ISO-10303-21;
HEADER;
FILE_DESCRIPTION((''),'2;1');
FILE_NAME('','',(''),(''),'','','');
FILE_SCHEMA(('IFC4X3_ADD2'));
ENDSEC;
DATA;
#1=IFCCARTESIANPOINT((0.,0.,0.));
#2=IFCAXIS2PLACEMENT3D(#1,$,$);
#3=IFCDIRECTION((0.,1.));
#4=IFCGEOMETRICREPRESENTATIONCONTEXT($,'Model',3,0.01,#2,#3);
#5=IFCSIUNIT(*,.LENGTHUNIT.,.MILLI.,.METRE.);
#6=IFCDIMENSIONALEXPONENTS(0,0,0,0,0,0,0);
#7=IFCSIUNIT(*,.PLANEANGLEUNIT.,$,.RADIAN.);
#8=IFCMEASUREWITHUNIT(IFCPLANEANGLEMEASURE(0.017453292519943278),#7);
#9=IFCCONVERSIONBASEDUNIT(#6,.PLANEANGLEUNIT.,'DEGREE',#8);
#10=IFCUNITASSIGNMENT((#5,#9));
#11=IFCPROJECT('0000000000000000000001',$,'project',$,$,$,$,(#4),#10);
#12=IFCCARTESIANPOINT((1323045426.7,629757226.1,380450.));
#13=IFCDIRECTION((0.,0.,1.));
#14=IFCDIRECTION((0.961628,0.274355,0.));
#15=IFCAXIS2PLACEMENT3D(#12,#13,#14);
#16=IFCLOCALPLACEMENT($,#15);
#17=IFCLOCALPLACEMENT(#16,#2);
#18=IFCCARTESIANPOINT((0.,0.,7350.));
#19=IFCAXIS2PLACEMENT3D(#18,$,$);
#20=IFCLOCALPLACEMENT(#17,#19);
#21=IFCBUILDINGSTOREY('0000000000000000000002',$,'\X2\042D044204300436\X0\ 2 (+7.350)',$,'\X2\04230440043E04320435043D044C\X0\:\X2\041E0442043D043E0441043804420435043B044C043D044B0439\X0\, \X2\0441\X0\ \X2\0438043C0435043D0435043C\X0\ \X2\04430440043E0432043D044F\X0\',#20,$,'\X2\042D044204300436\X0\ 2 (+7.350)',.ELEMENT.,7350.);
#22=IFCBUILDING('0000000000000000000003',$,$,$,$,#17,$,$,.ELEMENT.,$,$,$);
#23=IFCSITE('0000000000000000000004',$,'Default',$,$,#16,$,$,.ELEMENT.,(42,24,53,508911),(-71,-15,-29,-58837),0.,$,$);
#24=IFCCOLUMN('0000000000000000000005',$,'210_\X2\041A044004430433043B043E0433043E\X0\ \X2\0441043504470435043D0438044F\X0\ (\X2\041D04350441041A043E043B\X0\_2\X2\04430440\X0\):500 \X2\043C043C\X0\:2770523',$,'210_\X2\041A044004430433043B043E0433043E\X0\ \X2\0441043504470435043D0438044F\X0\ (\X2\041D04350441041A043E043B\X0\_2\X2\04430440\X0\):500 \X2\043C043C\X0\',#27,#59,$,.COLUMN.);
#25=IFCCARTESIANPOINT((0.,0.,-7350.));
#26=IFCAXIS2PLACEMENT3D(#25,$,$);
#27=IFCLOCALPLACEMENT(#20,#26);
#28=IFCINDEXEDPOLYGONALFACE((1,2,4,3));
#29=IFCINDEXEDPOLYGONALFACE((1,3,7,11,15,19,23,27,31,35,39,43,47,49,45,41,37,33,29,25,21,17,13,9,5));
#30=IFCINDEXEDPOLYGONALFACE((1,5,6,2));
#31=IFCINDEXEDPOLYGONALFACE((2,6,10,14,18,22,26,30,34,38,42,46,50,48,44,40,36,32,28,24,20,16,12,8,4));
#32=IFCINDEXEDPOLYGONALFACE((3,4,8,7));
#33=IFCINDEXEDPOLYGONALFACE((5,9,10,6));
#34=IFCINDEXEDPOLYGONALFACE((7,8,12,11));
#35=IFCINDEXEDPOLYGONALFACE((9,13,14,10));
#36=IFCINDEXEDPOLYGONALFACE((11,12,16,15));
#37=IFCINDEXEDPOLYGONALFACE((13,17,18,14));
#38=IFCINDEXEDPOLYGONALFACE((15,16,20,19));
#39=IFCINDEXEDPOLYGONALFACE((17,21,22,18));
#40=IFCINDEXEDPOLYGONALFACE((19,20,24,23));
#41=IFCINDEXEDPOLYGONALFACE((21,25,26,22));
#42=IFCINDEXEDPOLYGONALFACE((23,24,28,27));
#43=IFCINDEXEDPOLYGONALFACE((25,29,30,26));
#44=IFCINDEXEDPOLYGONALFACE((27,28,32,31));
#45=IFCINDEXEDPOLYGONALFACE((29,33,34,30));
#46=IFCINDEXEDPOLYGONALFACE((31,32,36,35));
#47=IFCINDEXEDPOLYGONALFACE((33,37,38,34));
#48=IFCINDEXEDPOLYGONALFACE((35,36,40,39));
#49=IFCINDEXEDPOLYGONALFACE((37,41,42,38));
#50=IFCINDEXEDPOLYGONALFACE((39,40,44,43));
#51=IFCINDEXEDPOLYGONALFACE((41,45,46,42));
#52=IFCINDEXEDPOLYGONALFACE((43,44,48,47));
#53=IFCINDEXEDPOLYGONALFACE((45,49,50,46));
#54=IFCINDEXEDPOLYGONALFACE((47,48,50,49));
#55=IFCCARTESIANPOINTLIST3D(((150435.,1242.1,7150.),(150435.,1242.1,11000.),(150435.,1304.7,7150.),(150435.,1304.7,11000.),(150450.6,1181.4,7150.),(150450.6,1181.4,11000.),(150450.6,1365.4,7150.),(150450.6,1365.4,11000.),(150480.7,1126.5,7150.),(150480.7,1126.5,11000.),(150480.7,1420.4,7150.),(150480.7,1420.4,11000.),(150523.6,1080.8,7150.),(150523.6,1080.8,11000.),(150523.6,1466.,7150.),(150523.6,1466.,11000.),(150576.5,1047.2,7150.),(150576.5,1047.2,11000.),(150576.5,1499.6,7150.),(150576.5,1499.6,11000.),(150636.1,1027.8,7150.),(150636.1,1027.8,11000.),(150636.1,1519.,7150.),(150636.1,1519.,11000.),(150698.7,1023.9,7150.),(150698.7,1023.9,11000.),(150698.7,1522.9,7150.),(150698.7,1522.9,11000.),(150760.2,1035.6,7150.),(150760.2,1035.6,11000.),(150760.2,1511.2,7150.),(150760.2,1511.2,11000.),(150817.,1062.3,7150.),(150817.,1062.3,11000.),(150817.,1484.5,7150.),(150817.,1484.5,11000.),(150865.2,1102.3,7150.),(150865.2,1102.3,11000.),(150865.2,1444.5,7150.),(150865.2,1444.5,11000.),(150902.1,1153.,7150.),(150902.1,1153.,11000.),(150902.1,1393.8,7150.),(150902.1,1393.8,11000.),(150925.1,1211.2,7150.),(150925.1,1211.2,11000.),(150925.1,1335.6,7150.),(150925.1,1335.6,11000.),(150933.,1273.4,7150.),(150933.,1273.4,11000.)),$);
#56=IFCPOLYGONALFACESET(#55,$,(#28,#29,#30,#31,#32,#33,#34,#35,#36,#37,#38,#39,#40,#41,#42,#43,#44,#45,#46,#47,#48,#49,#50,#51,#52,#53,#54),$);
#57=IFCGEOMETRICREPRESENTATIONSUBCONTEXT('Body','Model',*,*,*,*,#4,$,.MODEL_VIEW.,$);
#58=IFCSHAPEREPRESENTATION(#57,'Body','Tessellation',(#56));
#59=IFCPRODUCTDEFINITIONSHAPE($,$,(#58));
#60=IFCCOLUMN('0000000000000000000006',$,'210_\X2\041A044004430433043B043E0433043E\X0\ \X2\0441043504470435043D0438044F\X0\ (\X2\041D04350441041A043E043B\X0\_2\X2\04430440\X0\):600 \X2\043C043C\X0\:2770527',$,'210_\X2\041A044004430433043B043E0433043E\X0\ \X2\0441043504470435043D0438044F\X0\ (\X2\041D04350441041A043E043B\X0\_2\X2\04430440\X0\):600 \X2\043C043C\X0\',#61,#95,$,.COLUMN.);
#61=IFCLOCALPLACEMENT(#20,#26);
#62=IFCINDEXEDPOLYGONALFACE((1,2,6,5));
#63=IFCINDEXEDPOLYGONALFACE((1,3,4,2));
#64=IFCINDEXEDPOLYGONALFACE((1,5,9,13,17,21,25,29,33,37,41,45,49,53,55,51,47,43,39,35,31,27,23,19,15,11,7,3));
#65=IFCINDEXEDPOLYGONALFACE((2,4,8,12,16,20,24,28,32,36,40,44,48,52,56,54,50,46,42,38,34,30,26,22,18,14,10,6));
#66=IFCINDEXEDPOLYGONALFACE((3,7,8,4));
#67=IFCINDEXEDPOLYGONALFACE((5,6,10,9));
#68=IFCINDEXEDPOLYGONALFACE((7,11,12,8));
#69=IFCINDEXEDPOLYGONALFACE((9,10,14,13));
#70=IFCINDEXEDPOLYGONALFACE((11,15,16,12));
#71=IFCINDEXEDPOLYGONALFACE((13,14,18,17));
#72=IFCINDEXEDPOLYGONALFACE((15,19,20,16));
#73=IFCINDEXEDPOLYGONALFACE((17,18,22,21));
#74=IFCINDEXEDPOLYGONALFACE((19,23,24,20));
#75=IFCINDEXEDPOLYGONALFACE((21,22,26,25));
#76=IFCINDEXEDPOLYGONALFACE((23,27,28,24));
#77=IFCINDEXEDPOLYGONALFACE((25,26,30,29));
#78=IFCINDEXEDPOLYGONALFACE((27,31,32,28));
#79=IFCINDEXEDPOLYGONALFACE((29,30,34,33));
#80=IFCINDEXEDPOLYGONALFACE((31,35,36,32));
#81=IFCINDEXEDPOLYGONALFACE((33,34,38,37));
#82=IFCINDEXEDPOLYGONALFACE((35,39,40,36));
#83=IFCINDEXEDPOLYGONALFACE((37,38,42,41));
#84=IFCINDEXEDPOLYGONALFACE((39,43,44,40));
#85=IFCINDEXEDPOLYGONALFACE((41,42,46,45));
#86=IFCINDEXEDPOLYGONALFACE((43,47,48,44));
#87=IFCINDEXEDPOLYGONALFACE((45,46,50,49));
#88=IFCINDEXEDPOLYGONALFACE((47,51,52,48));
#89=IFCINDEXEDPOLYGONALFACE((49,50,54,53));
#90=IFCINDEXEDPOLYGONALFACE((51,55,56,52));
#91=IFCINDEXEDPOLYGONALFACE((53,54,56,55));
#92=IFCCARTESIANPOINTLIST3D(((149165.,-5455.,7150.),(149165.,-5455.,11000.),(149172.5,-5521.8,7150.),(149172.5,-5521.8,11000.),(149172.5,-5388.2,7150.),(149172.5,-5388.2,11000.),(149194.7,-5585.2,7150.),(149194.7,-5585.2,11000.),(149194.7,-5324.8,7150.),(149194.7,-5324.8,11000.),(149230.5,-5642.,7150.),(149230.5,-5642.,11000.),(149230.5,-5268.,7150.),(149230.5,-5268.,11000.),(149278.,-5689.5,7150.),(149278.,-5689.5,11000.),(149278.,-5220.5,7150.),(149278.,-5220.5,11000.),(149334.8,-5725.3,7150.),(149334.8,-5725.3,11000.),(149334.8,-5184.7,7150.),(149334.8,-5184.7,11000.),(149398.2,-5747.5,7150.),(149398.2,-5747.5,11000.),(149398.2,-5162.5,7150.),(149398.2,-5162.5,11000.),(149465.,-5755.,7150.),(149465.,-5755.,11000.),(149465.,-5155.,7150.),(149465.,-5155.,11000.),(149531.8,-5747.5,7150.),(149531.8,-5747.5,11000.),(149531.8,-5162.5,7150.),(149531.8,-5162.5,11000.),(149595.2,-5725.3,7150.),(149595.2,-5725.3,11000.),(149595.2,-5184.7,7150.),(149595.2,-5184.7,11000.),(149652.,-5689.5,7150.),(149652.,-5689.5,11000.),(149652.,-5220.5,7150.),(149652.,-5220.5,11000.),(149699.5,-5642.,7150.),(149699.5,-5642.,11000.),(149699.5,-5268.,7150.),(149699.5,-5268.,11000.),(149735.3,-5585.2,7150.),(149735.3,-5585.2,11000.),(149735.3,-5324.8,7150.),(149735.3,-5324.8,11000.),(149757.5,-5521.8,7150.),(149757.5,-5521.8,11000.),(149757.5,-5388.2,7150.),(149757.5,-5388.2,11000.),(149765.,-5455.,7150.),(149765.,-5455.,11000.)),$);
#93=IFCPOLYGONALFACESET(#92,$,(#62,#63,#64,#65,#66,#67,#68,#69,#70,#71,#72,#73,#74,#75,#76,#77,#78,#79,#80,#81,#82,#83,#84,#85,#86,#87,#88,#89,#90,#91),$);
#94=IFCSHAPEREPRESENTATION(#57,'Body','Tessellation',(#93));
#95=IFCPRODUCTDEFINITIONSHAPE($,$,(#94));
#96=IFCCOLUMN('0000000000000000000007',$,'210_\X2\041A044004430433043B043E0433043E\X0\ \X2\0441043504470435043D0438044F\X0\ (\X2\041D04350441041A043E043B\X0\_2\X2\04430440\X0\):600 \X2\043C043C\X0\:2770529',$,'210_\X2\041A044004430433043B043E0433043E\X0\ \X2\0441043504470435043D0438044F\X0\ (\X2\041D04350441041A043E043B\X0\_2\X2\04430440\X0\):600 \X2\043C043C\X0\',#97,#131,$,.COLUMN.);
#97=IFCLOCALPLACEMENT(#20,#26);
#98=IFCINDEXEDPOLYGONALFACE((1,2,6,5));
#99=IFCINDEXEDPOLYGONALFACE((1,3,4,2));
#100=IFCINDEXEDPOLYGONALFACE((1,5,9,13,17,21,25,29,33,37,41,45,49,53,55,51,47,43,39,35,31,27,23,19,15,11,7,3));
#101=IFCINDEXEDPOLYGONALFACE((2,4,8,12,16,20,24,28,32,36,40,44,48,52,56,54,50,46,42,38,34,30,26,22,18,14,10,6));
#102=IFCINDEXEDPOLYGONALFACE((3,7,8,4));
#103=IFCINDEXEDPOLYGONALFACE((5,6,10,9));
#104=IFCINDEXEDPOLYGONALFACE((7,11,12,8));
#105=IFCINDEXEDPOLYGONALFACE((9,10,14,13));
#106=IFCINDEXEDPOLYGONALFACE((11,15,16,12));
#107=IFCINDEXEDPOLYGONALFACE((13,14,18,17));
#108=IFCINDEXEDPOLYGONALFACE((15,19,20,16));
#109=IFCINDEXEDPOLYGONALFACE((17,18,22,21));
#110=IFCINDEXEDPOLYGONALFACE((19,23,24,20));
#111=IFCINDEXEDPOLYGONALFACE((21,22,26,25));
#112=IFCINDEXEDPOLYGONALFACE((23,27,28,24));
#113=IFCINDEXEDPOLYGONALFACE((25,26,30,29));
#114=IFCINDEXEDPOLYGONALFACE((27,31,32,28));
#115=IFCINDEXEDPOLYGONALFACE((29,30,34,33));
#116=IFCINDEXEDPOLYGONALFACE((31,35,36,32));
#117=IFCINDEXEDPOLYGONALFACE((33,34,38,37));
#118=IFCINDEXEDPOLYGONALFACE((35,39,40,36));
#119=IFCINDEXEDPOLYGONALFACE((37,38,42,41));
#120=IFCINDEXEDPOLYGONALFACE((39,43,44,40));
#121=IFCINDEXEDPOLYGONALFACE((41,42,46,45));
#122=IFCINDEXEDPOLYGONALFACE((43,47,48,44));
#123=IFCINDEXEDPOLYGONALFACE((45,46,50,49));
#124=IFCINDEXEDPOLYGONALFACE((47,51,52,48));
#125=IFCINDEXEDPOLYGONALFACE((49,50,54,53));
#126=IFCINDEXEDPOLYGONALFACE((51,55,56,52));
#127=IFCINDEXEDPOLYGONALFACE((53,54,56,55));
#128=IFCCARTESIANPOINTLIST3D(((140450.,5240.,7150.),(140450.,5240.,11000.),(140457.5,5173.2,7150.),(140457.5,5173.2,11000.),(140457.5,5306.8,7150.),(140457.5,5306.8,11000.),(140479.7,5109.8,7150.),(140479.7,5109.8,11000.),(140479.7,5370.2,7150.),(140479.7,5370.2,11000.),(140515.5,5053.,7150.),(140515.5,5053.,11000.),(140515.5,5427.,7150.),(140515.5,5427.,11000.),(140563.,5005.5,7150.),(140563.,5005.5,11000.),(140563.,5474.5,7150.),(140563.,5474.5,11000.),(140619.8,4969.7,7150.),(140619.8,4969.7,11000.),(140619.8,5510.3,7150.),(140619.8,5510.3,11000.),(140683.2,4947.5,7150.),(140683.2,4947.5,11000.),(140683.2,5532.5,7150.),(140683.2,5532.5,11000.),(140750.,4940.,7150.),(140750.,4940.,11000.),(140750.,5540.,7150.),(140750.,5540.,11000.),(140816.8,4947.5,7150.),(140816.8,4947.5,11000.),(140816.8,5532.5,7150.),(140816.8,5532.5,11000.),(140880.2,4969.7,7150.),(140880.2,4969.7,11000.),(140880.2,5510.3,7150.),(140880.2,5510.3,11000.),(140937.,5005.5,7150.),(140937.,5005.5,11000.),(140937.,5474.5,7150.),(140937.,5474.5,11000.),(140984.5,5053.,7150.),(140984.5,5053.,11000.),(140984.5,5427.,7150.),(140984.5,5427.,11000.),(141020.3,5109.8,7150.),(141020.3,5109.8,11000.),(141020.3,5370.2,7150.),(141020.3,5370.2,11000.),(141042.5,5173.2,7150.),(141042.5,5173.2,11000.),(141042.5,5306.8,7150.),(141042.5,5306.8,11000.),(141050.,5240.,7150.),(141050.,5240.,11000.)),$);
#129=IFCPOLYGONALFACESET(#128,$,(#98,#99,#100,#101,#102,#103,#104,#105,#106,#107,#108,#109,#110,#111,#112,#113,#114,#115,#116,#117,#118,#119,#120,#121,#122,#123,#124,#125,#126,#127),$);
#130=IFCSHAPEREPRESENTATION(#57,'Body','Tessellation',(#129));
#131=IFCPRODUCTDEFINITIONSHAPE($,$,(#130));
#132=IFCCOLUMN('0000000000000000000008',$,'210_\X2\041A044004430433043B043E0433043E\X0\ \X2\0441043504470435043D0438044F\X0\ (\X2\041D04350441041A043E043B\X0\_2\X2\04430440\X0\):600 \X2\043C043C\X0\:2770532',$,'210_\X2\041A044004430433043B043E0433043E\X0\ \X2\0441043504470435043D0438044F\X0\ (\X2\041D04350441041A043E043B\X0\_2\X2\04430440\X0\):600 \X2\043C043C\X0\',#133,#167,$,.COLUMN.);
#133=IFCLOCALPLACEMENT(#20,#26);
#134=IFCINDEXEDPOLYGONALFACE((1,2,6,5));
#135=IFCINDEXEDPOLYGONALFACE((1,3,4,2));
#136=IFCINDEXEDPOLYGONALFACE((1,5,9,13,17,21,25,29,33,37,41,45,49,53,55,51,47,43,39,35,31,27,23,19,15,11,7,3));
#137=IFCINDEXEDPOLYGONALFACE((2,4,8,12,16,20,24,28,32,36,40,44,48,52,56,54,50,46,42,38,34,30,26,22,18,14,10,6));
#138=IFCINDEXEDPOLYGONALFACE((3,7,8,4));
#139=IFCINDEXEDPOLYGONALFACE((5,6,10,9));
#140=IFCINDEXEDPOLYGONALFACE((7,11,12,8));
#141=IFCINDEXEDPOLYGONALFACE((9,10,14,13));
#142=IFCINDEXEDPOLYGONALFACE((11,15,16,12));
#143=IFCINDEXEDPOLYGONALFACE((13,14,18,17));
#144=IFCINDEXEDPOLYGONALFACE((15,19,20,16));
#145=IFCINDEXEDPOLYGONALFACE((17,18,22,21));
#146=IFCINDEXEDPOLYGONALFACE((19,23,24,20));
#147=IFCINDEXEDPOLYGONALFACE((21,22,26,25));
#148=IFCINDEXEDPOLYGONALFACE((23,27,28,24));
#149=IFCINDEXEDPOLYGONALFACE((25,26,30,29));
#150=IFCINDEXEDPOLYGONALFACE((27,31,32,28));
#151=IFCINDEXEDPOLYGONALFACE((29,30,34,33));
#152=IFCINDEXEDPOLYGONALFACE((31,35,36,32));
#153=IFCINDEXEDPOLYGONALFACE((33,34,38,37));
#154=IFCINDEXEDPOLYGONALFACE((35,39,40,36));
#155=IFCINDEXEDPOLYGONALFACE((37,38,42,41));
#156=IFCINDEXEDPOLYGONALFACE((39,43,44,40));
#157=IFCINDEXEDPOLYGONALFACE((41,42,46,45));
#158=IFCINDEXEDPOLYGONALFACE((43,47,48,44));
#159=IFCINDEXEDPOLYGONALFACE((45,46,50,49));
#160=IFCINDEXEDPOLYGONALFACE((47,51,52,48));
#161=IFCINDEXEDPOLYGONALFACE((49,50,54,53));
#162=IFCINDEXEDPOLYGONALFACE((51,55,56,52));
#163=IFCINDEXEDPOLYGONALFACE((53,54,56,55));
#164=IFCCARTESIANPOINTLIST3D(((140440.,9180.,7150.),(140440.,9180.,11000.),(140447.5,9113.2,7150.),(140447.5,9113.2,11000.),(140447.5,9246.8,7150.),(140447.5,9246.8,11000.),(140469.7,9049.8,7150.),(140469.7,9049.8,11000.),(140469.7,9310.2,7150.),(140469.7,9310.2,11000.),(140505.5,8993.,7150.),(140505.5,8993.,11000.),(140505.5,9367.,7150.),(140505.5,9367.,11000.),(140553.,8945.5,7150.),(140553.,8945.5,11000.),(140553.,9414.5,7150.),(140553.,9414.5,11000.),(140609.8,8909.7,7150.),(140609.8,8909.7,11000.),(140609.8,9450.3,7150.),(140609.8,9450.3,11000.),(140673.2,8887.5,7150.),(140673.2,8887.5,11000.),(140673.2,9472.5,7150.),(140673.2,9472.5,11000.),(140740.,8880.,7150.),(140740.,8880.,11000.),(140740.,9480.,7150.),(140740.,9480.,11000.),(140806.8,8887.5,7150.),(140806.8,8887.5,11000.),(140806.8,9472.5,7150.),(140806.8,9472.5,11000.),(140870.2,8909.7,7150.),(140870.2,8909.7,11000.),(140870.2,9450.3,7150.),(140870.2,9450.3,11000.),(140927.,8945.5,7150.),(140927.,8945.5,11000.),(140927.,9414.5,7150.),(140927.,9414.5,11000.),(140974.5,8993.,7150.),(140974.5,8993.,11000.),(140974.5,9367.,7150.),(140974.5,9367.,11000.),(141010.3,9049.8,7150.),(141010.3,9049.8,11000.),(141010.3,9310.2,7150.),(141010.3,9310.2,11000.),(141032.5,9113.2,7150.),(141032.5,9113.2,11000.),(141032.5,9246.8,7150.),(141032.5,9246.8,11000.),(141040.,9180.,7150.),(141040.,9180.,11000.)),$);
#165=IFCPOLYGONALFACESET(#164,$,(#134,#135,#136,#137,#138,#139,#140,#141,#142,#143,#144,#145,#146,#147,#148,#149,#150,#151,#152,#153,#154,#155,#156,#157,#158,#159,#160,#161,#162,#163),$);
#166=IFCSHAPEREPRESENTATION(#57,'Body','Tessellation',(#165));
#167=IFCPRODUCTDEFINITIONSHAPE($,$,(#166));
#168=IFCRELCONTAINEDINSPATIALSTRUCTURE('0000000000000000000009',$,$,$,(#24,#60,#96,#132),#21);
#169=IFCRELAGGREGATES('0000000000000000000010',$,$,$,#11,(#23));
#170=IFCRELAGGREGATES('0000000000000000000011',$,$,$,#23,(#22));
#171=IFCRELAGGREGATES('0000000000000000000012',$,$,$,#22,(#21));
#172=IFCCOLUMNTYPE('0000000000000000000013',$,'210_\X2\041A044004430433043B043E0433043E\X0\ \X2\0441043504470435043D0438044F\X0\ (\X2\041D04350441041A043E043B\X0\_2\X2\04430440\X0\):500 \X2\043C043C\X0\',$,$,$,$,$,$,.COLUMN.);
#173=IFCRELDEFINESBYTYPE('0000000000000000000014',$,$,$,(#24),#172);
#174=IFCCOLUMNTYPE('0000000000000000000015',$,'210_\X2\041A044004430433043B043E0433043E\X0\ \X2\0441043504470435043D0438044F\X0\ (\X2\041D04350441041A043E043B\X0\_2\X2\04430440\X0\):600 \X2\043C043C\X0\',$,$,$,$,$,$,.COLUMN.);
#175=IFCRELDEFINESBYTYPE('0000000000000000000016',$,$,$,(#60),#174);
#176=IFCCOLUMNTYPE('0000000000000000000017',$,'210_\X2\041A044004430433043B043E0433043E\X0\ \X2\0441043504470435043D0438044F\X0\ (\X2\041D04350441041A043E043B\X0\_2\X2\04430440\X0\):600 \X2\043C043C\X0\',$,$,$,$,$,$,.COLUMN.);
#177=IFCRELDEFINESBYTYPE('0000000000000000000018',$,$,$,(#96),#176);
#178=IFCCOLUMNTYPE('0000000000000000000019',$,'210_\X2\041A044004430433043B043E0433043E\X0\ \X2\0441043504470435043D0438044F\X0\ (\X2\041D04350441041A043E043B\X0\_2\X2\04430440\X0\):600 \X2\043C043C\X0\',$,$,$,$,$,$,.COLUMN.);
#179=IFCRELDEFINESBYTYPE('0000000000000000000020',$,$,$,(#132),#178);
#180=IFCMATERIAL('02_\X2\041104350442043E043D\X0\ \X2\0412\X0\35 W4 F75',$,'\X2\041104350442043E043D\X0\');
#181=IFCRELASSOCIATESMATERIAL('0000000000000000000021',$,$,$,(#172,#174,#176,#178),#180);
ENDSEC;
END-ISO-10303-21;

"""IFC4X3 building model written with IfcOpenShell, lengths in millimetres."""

from ifc_helpers import new_model, entity, si_unit, converted_unit, direction, frame, frame_2d, origin, origin_2d_with_axis, place, context, subcontext, project, spatial, circle, extrude, source, transform, mapped, material, material_profile, profile_set, type_object, type_shapes, element, save


model = new_model("IFC4X3")

# Units and contexts
model_context = context("Model", 3, precision=0.01, world=origin(), true_north=direction((0.0, 1.0)))
body_context = subcontext(model_context, "Body", "Model", "MODEL_VIEW")
ifc_project = project(units=[si_unit("LENGTHUNIT", "METRE", prefix="MILLI"), converted_unit("PLANEANGLEUNIT", "DEGREE", entity("IfcPlaneAngleMeasure", 0.017453292519943278), si_unit("PLANEANGLEUNIT", "RADIAN"), dimensions=[0, 0, 0, 0, 0, 0, 0])], contexts=[model_context])

# Site, building, storey
site_placement = place(None, frame((1323045426.7, 629757226.1, 380450.0), z_axis=(0.0, 0.0, 1.0), x_axis=(0.961628, 0.274355, 0.0)))
site = spatial("IfcSite", under=ifc_project, at=site_placement, Name="Default", CompositionType="ELEMENT", RefLatitude=(42, 24, 53, 508911), RefLongitude=(-71, -15, -29, -58837), RefElevation=0.0)
building_placement = place(site_placement, origin())
building = spatial("IfcBuilding", under=site, at=building_placement, CompositionType="ELEMENT")
storey_placement = place(building_placement, frame((0.0, 0.0, 7350.0)))
storey = spatial("IfcBuildingStorey", under=building, at=storey_placement, Name="Этаж 2 (+7.350)", ObjectType="Уровень:Относительный, с именем уровня", LongName="Этаж 2 (+7.350)", CompositionType="ELEMENT", Elevation=7350.0)

# Columns
ifc_material = material(Name="02_Бетон В35 W4 F75", Category="Бетон")
ifc_material_profile_1 = material_profile(ifc_material, circle(Radius=250.0, at=frame_2d((0.0, 0.0), x_axis=(1.0, 0.0))), Name="500 мм")
ifc_profile_set_1 = profile_set([ifc_material_profile_1], Name="500 мм")
column_type_1 = type_object("IfcColumnType", Name="210_Круглого сечения (НесКол_2ур):500 мм", PredefinedType="COLUMN", material=ifc_profile_set_1)
shared_shape_1 = source(origin(), body_context, "Body", "SweptSolid", [
    extrude(circle(Radius=250.0, at=frame_2d((0.0, 0.0), x_axis=(1.0, 0.0))), frame((150683.0, 1273.4, 7150.0)), (0.0, 0.0, 1.0), 3850.0),
])
type_shapes(column_type_1, [shared_shape_1])
column_1_placement = place(storey_placement, frame((0.0, 0.0, -7350.0)))
element("IfcColumn", 1, at=column_1_placement, inside=storey, type_object=column_type_1, Name="210_Круглого сечения (НесКол_2ур):500 мм:2770523", ObjectType="210_Круглого сечения (НесКол_2ур):500 мм", PredefinedType="COLUMN", context=body_context, shape_type="MappedRepresentation", body=[
    mapped(shared_shape_1, transform((0.0, 0.0, 0.0), scale=1.0)),
])
ifc_material_profile_2 = material_profile(ifc_material, circle(Radius=300.0, at=origin_2d_with_axis()), Name="600 мм")
ifc_profile_set_2 = profile_set([ifc_material_profile_2], Name="600 мм")
column_type_2 = type_object("IfcColumnType", Name="210_Круглого сечения (НесКол_2ур):600 мм", PredefinedType="COLUMN", material=ifc_profile_set_2)
shared_shape_2 = source(origin(), body_context, "Body", "SweptSolid", [
    extrude(circle(Radius=300.0, at=origin_2d_with_axis()), frame((149465.0, -5455.0, 7150.0)), (0.0, 0.0, 1.0), 3850.0),
])
type_shapes(column_type_2, [shared_shape_2])
column_2_placement = place(storey_placement, frame((0.0, 0.0, -7350.0)))
element("IfcColumn", 2, at=column_2_placement, inside=storey, type_object=column_type_2, Name="210_Круглого сечения (НесКол_2ур):600 мм:2770527", ObjectType="210_Круглого сечения (НесКол_2ур):600 мм", PredefinedType="COLUMN", context=body_context, shape_type="MappedRepresentation", body=[
    mapped(shared_shape_2, transform((0.0, 0.0, 0.0), scale=1.0)),
])
column_type_3 = type_object("IfcColumnType", Name="210_Круглого сечения (НесКол_2ур):600 мм", PredefinedType="COLUMN", material=ifc_profile_set_2)
shared_shape_3 = source(origin(), body_context, "Body", "SweptSolid", [
    extrude(circle(Radius=300.0, at=origin_2d_with_axis()), frame((140750.0, 5240.0, 7150.0)), (0.0, 0.0, 1.0), 3850.0),
])
type_shapes(column_type_3, [shared_shape_3])
column_3_placement = place(storey_placement, frame((0.0, 0.0, -7350.0)))
element("IfcColumn", 3, at=column_3_placement, inside=storey, type_object=column_type_3, Name="210_Круглого сечения (НесКол_2ур):600 мм:2770529", ObjectType="210_Круглого сечения (НесКол_2ур):600 мм", PredefinedType="COLUMN", context=body_context, shape_type="MappedRepresentation", body=[
    mapped(shared_shape_3, transform((0.0, 0.0, 0.0), scale=1.0)),
])
column_type_4 = type_object("IfcColumnType", Name="210_Круглого сечения (НесКол_2ур):600 мм", PredefinedType="COLUMN", material=ifc_profile_set_2)
shared_shape_4 = source(origin(), body_context, "Body", "SweptSolid", [
    extrude(circle(Radius=300.0, at=origin_2d_with_axis()), frame((140740.0, 9180.0, 7150.0)), (0.0, 0.0, 1.0), 3850.0),
])
type_shapes(column_type_4, [shared_shape_4])
column_4_placement = place(storey_placement, frame((0.0, 0.0, -7350.0)))
element("IfcColumn", 4, at=column_4_placement, inside=storey, type_object=column_type_4, Name="210_Круглого сечения (НесКол_2ур):600 мм:2770532", ObjectType="210_Круглого сечения (НесКол_2ур):600 мм", PredefinedType="COLUMN", context=body_context, shape_type="MappedRepresentation", body=[
    mapped(shared_shape_4, transform((0.0, 0.0, 0.0), scale=1.0)),
])

save(model, "model.ifc")
